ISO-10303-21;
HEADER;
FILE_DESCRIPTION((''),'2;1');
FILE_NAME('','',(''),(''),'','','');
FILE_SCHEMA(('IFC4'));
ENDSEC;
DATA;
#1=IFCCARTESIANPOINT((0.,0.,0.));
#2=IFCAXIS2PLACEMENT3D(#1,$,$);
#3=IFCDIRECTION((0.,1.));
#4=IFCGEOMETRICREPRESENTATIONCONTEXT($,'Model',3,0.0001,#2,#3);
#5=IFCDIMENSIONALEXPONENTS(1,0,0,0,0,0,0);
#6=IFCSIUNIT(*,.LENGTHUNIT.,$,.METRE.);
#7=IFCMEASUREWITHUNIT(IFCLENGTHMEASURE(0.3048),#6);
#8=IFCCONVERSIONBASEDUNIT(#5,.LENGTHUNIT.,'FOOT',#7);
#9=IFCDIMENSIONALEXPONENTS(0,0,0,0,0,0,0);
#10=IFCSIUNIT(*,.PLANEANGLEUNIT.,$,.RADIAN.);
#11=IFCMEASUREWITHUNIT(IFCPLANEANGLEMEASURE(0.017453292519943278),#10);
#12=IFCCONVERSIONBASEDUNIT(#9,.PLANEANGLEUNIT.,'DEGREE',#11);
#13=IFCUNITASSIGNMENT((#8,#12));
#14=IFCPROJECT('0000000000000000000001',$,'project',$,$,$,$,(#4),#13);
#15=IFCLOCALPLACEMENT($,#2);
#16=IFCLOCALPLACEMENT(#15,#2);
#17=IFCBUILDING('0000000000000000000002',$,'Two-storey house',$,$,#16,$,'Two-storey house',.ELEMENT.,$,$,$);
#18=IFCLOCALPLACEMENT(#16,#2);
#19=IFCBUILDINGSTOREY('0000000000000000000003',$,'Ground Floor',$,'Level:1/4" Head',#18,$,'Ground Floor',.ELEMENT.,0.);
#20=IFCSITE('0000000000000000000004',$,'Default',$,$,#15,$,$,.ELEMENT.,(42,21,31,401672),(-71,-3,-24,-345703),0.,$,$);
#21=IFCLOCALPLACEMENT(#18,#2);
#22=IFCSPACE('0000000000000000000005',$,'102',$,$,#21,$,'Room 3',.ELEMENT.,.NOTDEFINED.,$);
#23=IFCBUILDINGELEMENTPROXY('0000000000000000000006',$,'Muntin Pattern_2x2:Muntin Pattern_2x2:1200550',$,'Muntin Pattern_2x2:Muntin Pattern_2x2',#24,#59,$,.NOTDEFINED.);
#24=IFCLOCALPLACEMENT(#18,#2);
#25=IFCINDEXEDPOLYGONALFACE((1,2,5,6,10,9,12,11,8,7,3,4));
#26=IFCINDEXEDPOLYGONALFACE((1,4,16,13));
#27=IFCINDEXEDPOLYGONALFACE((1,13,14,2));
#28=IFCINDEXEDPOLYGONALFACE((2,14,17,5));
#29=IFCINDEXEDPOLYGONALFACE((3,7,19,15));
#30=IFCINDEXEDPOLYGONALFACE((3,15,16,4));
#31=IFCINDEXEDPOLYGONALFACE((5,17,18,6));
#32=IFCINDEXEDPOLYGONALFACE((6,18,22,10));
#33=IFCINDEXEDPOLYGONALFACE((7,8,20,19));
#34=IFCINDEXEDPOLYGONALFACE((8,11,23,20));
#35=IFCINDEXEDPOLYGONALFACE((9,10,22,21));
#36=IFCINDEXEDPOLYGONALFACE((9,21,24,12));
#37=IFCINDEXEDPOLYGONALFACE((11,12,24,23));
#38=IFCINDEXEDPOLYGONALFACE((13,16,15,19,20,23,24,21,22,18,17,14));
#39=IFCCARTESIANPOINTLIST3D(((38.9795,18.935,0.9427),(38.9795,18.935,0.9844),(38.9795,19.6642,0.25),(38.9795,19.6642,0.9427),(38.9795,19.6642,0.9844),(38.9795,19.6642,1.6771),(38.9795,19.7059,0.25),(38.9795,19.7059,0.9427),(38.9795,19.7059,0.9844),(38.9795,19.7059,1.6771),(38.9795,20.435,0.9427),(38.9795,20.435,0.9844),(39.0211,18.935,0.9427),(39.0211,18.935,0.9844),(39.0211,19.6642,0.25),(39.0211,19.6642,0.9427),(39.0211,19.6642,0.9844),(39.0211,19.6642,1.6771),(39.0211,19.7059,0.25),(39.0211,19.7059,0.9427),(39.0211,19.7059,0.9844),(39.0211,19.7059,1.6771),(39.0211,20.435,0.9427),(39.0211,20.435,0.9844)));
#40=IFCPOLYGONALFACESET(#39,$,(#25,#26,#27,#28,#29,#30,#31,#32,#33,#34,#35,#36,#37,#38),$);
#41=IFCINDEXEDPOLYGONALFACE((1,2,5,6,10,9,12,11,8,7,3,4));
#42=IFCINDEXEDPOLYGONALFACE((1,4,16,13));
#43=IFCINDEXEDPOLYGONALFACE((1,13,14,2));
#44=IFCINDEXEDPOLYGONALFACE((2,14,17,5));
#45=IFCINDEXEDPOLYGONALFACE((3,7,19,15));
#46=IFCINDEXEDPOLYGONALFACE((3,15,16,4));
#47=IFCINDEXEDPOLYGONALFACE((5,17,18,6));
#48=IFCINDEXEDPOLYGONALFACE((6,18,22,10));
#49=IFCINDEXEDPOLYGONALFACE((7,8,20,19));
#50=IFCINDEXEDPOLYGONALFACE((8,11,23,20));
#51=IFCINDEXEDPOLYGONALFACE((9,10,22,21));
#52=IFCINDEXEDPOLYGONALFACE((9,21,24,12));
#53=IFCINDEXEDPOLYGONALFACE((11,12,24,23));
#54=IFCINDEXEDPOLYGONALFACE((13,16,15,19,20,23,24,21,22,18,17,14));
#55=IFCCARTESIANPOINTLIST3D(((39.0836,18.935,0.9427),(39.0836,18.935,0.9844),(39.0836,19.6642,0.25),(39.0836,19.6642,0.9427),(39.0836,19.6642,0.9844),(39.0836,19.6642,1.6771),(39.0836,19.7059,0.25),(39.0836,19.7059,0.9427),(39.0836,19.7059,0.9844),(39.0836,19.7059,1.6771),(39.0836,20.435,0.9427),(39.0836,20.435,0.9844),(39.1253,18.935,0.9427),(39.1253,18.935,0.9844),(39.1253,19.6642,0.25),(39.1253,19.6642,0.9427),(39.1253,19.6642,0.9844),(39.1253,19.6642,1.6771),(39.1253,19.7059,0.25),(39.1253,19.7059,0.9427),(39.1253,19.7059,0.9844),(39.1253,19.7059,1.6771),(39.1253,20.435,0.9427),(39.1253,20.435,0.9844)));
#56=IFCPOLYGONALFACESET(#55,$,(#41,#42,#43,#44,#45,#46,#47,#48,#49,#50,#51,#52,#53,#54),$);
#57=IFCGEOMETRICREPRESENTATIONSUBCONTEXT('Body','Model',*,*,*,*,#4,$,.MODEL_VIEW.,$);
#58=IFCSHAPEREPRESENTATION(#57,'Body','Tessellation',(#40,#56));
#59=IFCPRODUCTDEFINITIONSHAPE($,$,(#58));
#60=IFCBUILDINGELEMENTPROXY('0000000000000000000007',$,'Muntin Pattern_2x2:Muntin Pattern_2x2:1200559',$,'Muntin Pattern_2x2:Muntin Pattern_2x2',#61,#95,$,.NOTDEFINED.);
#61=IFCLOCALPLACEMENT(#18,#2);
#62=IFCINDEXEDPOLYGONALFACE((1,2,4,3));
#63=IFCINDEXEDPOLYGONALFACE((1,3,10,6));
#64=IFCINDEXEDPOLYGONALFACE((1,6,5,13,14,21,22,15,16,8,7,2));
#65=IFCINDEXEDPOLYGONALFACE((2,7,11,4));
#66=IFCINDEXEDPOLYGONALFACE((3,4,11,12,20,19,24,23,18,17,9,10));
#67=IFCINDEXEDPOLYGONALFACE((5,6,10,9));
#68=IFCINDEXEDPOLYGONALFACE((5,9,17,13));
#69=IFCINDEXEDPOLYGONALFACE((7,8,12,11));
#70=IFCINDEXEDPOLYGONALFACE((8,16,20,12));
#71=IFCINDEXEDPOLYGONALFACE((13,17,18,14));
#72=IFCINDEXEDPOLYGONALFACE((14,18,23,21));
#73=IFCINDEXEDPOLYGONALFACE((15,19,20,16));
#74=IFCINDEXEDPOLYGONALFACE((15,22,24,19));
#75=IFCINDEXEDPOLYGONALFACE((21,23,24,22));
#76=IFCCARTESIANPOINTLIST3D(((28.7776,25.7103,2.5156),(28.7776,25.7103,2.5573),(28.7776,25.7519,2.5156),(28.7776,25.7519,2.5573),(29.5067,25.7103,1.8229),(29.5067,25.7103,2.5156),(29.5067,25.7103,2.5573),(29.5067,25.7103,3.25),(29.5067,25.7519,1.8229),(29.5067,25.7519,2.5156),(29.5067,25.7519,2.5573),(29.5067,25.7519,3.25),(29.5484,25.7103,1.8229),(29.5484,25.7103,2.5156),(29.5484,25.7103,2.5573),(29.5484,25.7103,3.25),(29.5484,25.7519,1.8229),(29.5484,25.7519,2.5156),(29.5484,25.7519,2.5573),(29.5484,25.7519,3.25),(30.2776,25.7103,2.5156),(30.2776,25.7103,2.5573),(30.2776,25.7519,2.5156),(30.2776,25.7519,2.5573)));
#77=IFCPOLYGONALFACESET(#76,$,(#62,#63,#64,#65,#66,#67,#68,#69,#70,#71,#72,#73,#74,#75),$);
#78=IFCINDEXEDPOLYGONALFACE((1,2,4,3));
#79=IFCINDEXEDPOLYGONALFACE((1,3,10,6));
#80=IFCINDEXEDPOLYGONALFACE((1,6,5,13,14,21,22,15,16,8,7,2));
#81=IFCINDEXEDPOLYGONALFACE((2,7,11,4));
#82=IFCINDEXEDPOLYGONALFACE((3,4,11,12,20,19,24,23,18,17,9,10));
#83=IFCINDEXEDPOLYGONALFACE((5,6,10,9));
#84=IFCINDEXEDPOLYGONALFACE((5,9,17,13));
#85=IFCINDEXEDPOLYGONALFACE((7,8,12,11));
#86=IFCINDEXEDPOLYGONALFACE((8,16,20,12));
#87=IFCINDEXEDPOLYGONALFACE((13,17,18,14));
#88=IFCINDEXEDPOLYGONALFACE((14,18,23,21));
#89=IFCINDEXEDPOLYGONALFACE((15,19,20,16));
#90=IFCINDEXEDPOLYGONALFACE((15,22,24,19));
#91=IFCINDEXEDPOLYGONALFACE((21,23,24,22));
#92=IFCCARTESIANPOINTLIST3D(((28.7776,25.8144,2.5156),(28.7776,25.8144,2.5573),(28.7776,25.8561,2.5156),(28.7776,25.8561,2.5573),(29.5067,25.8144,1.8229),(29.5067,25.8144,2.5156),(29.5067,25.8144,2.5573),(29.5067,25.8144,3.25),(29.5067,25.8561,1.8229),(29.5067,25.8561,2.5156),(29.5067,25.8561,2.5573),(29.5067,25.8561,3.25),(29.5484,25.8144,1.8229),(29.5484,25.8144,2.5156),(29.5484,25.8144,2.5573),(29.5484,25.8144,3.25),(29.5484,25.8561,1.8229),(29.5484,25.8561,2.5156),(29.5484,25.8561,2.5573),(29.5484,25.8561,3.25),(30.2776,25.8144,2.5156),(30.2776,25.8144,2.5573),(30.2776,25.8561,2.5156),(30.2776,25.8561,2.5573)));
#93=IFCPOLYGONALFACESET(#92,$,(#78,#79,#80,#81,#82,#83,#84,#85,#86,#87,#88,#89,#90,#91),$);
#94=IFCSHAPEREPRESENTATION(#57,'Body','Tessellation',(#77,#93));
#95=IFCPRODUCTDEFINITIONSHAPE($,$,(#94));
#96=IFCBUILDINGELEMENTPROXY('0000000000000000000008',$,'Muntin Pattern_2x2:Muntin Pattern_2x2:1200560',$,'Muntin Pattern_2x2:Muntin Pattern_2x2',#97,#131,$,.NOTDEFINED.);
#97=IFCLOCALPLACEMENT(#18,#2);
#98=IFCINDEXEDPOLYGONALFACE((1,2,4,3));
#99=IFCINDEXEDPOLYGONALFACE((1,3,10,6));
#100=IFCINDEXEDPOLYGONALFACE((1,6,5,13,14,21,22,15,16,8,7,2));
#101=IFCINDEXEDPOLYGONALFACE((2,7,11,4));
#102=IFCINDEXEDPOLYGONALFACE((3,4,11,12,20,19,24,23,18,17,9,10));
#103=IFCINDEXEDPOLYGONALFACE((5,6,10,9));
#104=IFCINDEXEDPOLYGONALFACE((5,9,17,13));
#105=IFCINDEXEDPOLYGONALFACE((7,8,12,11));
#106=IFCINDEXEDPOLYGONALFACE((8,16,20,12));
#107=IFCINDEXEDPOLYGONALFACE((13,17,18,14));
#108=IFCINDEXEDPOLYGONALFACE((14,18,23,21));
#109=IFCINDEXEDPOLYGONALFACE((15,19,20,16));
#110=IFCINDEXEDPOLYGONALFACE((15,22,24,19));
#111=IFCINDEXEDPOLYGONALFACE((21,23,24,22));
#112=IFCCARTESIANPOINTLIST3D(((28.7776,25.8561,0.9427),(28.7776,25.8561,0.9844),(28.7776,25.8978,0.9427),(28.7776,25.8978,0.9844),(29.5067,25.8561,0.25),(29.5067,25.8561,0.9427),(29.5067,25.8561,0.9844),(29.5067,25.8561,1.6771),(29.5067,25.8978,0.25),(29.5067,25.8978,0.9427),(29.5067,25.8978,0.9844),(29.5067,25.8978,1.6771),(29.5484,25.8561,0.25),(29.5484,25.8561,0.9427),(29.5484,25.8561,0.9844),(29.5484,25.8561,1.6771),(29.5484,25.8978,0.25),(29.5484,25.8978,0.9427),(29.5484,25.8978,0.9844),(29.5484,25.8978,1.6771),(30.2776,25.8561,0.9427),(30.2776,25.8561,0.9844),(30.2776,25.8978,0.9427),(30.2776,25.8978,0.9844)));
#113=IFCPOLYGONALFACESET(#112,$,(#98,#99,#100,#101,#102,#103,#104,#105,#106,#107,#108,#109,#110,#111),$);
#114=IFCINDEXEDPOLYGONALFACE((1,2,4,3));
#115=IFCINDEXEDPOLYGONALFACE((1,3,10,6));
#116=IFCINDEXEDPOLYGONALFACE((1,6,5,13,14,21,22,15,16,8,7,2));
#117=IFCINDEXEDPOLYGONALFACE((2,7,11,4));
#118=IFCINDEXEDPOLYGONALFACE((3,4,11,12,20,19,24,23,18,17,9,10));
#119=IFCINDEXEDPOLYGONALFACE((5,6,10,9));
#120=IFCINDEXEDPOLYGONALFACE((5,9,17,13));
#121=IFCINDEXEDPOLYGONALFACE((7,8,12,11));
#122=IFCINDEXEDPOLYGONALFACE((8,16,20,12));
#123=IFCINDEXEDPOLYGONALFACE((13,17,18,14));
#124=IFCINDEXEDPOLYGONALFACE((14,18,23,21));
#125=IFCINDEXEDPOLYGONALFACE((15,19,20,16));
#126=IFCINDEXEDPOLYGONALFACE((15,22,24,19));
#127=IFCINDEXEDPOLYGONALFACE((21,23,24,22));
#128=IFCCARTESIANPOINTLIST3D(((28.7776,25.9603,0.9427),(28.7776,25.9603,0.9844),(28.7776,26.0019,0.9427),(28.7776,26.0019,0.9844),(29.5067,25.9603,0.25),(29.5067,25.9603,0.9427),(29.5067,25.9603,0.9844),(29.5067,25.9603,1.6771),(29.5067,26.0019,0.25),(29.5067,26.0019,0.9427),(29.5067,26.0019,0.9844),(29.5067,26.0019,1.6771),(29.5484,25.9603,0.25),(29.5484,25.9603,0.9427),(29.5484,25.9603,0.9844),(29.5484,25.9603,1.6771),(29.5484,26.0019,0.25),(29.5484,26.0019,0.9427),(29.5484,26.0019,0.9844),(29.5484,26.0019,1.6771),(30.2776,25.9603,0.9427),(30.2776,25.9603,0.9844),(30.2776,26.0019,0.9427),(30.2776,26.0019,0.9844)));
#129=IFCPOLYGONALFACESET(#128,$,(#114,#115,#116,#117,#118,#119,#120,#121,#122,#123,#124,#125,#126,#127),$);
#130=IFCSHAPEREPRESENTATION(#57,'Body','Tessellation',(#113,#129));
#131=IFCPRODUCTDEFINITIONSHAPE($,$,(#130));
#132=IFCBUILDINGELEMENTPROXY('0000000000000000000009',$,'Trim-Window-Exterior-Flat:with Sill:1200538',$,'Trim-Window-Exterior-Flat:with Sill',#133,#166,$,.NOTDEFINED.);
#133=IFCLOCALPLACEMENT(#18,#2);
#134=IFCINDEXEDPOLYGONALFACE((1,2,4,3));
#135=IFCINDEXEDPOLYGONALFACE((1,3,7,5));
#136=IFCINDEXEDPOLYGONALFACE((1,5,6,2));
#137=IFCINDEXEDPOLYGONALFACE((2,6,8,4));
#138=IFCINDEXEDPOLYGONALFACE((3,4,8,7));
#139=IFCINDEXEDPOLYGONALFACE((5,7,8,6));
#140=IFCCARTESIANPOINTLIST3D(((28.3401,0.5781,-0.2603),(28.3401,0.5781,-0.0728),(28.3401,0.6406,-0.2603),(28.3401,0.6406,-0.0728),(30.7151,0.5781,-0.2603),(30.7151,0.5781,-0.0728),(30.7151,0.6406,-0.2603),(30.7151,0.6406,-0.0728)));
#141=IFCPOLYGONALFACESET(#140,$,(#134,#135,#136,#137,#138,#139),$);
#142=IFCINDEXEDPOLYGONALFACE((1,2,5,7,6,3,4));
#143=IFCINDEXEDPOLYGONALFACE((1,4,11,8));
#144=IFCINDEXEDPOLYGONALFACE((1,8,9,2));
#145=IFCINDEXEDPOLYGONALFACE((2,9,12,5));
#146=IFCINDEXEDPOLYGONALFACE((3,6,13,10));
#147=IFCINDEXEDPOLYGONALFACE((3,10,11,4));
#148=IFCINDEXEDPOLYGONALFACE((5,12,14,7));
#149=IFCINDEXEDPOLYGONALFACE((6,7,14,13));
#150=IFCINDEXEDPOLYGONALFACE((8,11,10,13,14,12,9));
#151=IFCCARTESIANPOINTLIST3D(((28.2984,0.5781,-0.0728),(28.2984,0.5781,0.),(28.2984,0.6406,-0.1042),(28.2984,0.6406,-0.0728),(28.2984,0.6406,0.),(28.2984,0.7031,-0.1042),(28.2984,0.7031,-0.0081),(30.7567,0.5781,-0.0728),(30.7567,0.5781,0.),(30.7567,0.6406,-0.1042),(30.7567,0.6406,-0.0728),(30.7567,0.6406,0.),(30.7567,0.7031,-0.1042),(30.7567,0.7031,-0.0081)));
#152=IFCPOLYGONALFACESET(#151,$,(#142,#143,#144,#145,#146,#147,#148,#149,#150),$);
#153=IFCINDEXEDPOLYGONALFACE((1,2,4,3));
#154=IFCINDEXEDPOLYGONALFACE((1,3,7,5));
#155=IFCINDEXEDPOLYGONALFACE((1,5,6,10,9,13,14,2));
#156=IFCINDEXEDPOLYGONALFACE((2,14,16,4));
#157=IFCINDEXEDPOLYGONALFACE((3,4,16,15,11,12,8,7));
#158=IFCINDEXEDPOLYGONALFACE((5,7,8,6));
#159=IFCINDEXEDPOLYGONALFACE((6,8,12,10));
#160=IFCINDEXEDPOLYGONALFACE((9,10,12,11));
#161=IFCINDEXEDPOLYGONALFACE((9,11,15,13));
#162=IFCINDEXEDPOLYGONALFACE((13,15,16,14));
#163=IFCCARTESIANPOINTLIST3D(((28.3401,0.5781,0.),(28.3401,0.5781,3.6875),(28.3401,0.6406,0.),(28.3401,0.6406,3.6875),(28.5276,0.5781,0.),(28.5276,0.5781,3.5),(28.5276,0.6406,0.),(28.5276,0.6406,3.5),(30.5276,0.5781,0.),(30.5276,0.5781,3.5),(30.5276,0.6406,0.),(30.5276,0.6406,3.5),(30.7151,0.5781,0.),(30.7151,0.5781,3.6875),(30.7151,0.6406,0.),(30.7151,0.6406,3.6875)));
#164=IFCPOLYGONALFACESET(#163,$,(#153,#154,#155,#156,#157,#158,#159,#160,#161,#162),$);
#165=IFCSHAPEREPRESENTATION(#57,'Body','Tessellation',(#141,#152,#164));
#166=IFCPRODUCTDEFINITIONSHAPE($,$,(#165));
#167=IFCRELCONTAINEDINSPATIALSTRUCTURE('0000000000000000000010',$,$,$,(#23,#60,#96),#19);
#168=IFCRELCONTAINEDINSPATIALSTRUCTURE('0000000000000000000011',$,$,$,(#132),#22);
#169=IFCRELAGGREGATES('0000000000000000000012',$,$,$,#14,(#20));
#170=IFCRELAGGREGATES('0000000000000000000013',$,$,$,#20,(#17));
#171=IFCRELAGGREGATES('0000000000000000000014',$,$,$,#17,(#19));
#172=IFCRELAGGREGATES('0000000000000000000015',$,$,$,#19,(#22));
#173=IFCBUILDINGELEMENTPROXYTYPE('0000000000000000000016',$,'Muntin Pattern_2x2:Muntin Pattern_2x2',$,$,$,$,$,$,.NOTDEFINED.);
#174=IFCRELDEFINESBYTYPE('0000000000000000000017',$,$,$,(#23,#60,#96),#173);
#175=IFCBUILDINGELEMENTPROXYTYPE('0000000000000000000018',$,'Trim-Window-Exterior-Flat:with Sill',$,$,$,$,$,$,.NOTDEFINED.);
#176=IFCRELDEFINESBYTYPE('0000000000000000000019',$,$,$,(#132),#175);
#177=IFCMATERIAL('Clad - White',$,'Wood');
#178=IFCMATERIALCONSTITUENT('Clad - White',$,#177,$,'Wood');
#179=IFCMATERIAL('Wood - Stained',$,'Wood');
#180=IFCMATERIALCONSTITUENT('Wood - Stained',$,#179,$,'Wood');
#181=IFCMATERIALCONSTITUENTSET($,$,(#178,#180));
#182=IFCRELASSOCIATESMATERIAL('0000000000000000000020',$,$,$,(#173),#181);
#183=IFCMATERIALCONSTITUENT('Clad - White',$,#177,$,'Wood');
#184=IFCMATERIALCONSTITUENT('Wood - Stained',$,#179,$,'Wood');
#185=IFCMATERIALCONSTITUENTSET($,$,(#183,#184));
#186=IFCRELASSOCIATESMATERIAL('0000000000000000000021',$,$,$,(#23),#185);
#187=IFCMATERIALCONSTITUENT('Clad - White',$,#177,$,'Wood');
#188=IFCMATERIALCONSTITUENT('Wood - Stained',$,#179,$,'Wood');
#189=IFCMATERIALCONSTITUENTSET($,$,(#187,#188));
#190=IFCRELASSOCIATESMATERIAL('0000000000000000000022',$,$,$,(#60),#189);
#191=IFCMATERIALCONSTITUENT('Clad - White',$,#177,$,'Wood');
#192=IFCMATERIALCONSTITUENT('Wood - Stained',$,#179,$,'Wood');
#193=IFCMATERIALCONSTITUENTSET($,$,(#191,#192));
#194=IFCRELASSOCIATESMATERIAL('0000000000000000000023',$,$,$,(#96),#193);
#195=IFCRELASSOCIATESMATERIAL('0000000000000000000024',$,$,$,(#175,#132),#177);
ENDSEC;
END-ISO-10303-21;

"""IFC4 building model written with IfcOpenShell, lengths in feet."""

from ifc_helpers import new_model, entity, si_unit, converted_unit, direction, frame, origin, place, context, subcontext, project, spatial, indexed_curve, outline, extrude, source, transform, mapped, material, constituent, constituent_set, type_object, type_shapes, element, save


model = new_model("IFC4")

# Units and contexts
model_context = context("Model", 3, precision=0.0001, world=origin(), true_north=direction((0.0, 1.0)))
body_context = subcontext(model_context, "Body", "Model", "MODEL_VIEW")
ifc_project = project(units=[converted_unit("LENGTHUNIT", "FOOT", entity("IfcLengthMeasure", 0.3048), si_unit("LENGTHUNIT", "METRE"), dimensions=[1, 0, 0, 0, 0, 0, 0]), converted_unit("PLANEANGLEUNIT", "DEGREE", entity("IfcPlaneAngleMeasure", 0.017453292519943278), si_unit("PLANEANGLEUNIT", "RADIAN"), dimensions=[0, 0, 0, 0, 0, 0, 0])], contexts=[model_context])

# Site, building, storey
site_placement = place(None, origin())
site = spatial("IfcSite", under=ifc_project, at=site_placement, Name="Default", CompositionType="ELEMENT", RefLatitude=(42, 21, 31, 401672), RefLongitude=(-71, -3, -24, -345703), RefElevation=0.0)
building_placement = place(site_placement, origin())
building = spatial("IfcBuilding", under=site, at=building_placement, Name="Two-storey house", LongName="Two-storey house", CompositionType="ELEMENT")
storey_placement = place(building_placement, origin())
storey = spatial("IfcBuildingStorey", under=building, at=storey_placement, Name="Ground Floor", ObjectType="Level:1/4\" Head", LongName="Ground Floor", CompositionType="ELEMENT", Elevation=0.0)

# Shared definitions
ifc_material_1 = material(Name="Wood - Stained", Category="Wood")

# Building element proxies
ifc_material_2 = material(Name="Clad - White", Category="Wood")
ifc_constituent_1 = constituent(ifc_material_2, Name="Clad - White", Category="Wood")
ifc_constituent_2 = constituent(ifc_material_1, Name="Wood - Stained", Category="Wood")
ifc_constituent_set_1 = constituent_set(constituents=[ifc_constituent_1, ifc_constituent_2])
building_element_proxy_type_1 = type_object("IfcBuildingElementProxyType", Name="Muntin Pattern_2x2:Muntin Pattern_2x2", PredefinedType="NOTDEFINED", material=ifc_constituent_set_1)
shared_shape_1 = source(origin(), body_context, "Body", "SweptSolid", [
    extrude(outline(indexed_curve([(0.0208, -0.0208), (0.7135, -0.0208), (0.7135, 0.0208), (0.0208, 0.0208), (0.0208, 0.75), (-0.0208, 0.75), (-0.0208, 0.0208), (-0.7135, 0.0208), (-0.7135, -0.0208), (-0.0208, -0.0208), (-0.0208, -0.75), (0.0208, -0.75), (0.0208, -0.0208)], self_intersect=False)), frame((0.0, 0.0312, 0.7135), z_axis=(0.0, 1.0, 0.0), x_axis=(0.0, 0.0, 1.0)), (0.0, 0.0, 1.0), 0.0417),
    extrude(outline(indexed_curve([(0.0208, -0.0208), (0.7135, -0.0208), (0.7135, 0.0208), (0.0208, 0.0208), (0.0208, 0.75), (-0.0208, 0.75), (-0.0208, 0.0208), (-0.7135, 0.0208), (-0.7135, -0.0208), (-0.0208, -0.0208), (-0.0208, -0.75), (0.0208, -0.75), (0.0208, -0.0208)], self_intersect=False)), frame((0.0, -0.0729, 0.7135), z_axis=(0.0, 1.0, 0.0), x_axis=(0.0, 0.0, 1.0)), (0.0, 0.0, 1.0), 0.0417),
])
type_shapes(building_element_proxy_type_1, [shared_shape_1])
ifc_constituent_3 = constituent(ifc_material_2, Name="Clad - White", Category="Wood")
ifc_constituent_4 = constituent(ifc_material_1, Name="Wood - Stained", Category="Wood")
ifc_constituent_set_2 = constituent_set(constituents=[ifc_constituent_3, ifc_constituent_4])
proxy_1_placement = place(storey_placement, frame((39.0524, 19.685, 0.25), z_axis=(0.0, 0.0, 1.0), x_axis=(0.0, 1.0, 0.0)))
element("IfcBuildingElementProxy", 1, at=proxy_1_placement, inside=storey, type_object=building_element_proxy_type_1, material=ifc_constituent_set_2, Name="Muntin Pattern_2x2:Muntin Pattern_2x2:1200550", ObjectType="Muntin Pattern_2x2:Muntin Pattern_2x2", PredefinedType="NOTDEFINED", context=body_context, shape_type="MappedRepresentation", body=[
    mapped(shared_shape_1, transform((0.0, 0.0, 0.0), scale=1.0)),
])
ifc_constituent_5 = constituent(ifc_material_2, Name="Clad - White", Category="Wood")
ifc_constituent_6 = constituent(ifc_material_1, Name="Wood - Stained", Category="Wood")
ifc_constituent_set_3 = constituent_set(constituents=[ifc_constituent_5, ifc_constituent_6])
proxy_2_placement = place(storey_placement, frame((29.5276, 25.7832, 1.8229), z_axis=(0.0, 0.0, 1.0), x_axis=(-1.0, 0.0, 0.0)))
element("IfcBuildingElementProxy", 2, at=proxy_2_placement, inside=storey, type_object=building_element_proxy_type_1, material=ifc_constituent_set_3, Name="Muntin Pattern_2x2:Muntin Pattern_2x2:1200559", ObjectType="Muntin Pattern_2x2:Muntin Pattern_2x2", PredefinedType="NOTDEFINED", context=body_context, shape_type="MappedRepresentation", body=[
    mapped(shared_shape_1, transform((0.0, 0.0, 0.0), scale=1.0)),
])
ifc_constituent_7 = constituent(ifc_material_2, Name="Clad - White", Category="Wood")
ifc_constituent_8 = constituent(ifc_material_1, Name="Wood - Stained", Category="Wood")
ifc_constituent_set_4 = constituent_set(constituents=[ifc_constituent_7, ifc_constituent_8])
proxy_3_placement = place(storey_placement, frame((29.5276, 25.929, 0.25), z_axis=(0.0, 0.0, 1.0), x_axis=(-1.0, 0.0, 0.0)))
element("IfcBuildingElementProxy", 3, at=proxy_3_placement, inside=storey, type_object=building_element_proxy_type_1, material=ifc_constituent_set_4, Name="Muntin Pattern_2x2:Muntin Pattern_2x2:1200560", ObjectType="Muntin Pattern_2x2:Muntin Pattern_2x2", PredefinedType="NOTDEFINED", context=body_context, shape_type="MappedRepresentation", body=[
    mapped(shared_shape_1, transform((0.0, 0.0, 0.0), scale=1.0)),
])

# Shared definitions
space_1_placement = place(storey_placement, origin())
space_1 = spatial("IfcSpace", under=storey, at=space_1_placement, Name="102", LongName="Room 3", CompositionType="ELEMENT", PredefinedType="NOTDEFINED")

# Building element proxy
building_element_proxy_type_2 = type_object("IfcBuildingElementProxyType", Name="Trim-Window-Exterior-Flat:with Sill", PredefinedType="NOTDEFINED", material=ifc_material_2)
shared_shape_2 = source(origin(), body_context, "Body", "SweptSolid", [
    extrude(outline(indexed_curve([(-1.1875, -0.0938), (1.1875, -0.0938), (1.1875, 0.0938), (-1.1875, 0.0938), (-1.1875, -0.0938)], self_intersect=False)), frame((0.0, -3.6665, 0.0), z_axis=(0.0, 0.0, 1.0), x_axis=(-1.0, 0.0, 0.0)), (0.0, 0.0, 1.0), 0.0625),
    extrude(outline(indexed_curve([(-0.0625, -0.0525), (0.0, -0.0525), (0.0, -0.0211), (0.0625, -0.0211), (0.0625, 0.0517), (0.0, 0.0517), (-0.0625, 0.0436), (-0.0625, -0.0525)], self_intersect=False)), frame((-1.2292, -3.5517, 0.0625), z_axis=(1.0, 0.0, 0.0), x_axis=(0.0, 0.0, -1.0)), (0.0, 0.0, 1.0), 2.4583),
    extrude(outline(indexed_curve([(-1.8906, -1.1875), (1.7969, -1.1875), (1.7969, -1.0), (-1.7031, -1.0), (-1.7031, 1.0), (1.7969, 1.0), (1.7969, 1.1875), (-1.8906, 1.1875), (-1.8906, -1.1875)], self_intersect=False)), frame((0.0, -1.7031, 0.0), z_axis=(0.0, 0.0, 1.0), x_axis=(0.0, -1.0, 0.0)), (0.0, 0.0, 1.0), 0.0625),
])
type_shapes(building_element_proxy_type_2, [shared_shape_2])
for number, where, z_axis, x_axis, name in (
    (4, (29.5276, 0.5781, 3.5), (0.0, 1.0, 0.0), (-1.0, 0.0, 0.0), "Trim-Window-Exterior-Flat:with Sill:1200538"),
):
    element("IfcBuildingElementProxy", number, at=place(space_1_placement, frame(where, z_axis=z_axis, x_axis=x_axis)), inside=space_1, type_object=building_element_proxy_type_2, material=ifc_material_2, Name=name, ObjectType="Trim-Window-Exterior-Flat:with Sill", PredefinedType="NOTDEFINED", context=body_context, shape_type="MappedRepresentation", body=[
        mapped(shared_shape_2, transform((0.0, 0.0, 0.0), scale=1.0)),
    ])

save(model, "model.ifc")
